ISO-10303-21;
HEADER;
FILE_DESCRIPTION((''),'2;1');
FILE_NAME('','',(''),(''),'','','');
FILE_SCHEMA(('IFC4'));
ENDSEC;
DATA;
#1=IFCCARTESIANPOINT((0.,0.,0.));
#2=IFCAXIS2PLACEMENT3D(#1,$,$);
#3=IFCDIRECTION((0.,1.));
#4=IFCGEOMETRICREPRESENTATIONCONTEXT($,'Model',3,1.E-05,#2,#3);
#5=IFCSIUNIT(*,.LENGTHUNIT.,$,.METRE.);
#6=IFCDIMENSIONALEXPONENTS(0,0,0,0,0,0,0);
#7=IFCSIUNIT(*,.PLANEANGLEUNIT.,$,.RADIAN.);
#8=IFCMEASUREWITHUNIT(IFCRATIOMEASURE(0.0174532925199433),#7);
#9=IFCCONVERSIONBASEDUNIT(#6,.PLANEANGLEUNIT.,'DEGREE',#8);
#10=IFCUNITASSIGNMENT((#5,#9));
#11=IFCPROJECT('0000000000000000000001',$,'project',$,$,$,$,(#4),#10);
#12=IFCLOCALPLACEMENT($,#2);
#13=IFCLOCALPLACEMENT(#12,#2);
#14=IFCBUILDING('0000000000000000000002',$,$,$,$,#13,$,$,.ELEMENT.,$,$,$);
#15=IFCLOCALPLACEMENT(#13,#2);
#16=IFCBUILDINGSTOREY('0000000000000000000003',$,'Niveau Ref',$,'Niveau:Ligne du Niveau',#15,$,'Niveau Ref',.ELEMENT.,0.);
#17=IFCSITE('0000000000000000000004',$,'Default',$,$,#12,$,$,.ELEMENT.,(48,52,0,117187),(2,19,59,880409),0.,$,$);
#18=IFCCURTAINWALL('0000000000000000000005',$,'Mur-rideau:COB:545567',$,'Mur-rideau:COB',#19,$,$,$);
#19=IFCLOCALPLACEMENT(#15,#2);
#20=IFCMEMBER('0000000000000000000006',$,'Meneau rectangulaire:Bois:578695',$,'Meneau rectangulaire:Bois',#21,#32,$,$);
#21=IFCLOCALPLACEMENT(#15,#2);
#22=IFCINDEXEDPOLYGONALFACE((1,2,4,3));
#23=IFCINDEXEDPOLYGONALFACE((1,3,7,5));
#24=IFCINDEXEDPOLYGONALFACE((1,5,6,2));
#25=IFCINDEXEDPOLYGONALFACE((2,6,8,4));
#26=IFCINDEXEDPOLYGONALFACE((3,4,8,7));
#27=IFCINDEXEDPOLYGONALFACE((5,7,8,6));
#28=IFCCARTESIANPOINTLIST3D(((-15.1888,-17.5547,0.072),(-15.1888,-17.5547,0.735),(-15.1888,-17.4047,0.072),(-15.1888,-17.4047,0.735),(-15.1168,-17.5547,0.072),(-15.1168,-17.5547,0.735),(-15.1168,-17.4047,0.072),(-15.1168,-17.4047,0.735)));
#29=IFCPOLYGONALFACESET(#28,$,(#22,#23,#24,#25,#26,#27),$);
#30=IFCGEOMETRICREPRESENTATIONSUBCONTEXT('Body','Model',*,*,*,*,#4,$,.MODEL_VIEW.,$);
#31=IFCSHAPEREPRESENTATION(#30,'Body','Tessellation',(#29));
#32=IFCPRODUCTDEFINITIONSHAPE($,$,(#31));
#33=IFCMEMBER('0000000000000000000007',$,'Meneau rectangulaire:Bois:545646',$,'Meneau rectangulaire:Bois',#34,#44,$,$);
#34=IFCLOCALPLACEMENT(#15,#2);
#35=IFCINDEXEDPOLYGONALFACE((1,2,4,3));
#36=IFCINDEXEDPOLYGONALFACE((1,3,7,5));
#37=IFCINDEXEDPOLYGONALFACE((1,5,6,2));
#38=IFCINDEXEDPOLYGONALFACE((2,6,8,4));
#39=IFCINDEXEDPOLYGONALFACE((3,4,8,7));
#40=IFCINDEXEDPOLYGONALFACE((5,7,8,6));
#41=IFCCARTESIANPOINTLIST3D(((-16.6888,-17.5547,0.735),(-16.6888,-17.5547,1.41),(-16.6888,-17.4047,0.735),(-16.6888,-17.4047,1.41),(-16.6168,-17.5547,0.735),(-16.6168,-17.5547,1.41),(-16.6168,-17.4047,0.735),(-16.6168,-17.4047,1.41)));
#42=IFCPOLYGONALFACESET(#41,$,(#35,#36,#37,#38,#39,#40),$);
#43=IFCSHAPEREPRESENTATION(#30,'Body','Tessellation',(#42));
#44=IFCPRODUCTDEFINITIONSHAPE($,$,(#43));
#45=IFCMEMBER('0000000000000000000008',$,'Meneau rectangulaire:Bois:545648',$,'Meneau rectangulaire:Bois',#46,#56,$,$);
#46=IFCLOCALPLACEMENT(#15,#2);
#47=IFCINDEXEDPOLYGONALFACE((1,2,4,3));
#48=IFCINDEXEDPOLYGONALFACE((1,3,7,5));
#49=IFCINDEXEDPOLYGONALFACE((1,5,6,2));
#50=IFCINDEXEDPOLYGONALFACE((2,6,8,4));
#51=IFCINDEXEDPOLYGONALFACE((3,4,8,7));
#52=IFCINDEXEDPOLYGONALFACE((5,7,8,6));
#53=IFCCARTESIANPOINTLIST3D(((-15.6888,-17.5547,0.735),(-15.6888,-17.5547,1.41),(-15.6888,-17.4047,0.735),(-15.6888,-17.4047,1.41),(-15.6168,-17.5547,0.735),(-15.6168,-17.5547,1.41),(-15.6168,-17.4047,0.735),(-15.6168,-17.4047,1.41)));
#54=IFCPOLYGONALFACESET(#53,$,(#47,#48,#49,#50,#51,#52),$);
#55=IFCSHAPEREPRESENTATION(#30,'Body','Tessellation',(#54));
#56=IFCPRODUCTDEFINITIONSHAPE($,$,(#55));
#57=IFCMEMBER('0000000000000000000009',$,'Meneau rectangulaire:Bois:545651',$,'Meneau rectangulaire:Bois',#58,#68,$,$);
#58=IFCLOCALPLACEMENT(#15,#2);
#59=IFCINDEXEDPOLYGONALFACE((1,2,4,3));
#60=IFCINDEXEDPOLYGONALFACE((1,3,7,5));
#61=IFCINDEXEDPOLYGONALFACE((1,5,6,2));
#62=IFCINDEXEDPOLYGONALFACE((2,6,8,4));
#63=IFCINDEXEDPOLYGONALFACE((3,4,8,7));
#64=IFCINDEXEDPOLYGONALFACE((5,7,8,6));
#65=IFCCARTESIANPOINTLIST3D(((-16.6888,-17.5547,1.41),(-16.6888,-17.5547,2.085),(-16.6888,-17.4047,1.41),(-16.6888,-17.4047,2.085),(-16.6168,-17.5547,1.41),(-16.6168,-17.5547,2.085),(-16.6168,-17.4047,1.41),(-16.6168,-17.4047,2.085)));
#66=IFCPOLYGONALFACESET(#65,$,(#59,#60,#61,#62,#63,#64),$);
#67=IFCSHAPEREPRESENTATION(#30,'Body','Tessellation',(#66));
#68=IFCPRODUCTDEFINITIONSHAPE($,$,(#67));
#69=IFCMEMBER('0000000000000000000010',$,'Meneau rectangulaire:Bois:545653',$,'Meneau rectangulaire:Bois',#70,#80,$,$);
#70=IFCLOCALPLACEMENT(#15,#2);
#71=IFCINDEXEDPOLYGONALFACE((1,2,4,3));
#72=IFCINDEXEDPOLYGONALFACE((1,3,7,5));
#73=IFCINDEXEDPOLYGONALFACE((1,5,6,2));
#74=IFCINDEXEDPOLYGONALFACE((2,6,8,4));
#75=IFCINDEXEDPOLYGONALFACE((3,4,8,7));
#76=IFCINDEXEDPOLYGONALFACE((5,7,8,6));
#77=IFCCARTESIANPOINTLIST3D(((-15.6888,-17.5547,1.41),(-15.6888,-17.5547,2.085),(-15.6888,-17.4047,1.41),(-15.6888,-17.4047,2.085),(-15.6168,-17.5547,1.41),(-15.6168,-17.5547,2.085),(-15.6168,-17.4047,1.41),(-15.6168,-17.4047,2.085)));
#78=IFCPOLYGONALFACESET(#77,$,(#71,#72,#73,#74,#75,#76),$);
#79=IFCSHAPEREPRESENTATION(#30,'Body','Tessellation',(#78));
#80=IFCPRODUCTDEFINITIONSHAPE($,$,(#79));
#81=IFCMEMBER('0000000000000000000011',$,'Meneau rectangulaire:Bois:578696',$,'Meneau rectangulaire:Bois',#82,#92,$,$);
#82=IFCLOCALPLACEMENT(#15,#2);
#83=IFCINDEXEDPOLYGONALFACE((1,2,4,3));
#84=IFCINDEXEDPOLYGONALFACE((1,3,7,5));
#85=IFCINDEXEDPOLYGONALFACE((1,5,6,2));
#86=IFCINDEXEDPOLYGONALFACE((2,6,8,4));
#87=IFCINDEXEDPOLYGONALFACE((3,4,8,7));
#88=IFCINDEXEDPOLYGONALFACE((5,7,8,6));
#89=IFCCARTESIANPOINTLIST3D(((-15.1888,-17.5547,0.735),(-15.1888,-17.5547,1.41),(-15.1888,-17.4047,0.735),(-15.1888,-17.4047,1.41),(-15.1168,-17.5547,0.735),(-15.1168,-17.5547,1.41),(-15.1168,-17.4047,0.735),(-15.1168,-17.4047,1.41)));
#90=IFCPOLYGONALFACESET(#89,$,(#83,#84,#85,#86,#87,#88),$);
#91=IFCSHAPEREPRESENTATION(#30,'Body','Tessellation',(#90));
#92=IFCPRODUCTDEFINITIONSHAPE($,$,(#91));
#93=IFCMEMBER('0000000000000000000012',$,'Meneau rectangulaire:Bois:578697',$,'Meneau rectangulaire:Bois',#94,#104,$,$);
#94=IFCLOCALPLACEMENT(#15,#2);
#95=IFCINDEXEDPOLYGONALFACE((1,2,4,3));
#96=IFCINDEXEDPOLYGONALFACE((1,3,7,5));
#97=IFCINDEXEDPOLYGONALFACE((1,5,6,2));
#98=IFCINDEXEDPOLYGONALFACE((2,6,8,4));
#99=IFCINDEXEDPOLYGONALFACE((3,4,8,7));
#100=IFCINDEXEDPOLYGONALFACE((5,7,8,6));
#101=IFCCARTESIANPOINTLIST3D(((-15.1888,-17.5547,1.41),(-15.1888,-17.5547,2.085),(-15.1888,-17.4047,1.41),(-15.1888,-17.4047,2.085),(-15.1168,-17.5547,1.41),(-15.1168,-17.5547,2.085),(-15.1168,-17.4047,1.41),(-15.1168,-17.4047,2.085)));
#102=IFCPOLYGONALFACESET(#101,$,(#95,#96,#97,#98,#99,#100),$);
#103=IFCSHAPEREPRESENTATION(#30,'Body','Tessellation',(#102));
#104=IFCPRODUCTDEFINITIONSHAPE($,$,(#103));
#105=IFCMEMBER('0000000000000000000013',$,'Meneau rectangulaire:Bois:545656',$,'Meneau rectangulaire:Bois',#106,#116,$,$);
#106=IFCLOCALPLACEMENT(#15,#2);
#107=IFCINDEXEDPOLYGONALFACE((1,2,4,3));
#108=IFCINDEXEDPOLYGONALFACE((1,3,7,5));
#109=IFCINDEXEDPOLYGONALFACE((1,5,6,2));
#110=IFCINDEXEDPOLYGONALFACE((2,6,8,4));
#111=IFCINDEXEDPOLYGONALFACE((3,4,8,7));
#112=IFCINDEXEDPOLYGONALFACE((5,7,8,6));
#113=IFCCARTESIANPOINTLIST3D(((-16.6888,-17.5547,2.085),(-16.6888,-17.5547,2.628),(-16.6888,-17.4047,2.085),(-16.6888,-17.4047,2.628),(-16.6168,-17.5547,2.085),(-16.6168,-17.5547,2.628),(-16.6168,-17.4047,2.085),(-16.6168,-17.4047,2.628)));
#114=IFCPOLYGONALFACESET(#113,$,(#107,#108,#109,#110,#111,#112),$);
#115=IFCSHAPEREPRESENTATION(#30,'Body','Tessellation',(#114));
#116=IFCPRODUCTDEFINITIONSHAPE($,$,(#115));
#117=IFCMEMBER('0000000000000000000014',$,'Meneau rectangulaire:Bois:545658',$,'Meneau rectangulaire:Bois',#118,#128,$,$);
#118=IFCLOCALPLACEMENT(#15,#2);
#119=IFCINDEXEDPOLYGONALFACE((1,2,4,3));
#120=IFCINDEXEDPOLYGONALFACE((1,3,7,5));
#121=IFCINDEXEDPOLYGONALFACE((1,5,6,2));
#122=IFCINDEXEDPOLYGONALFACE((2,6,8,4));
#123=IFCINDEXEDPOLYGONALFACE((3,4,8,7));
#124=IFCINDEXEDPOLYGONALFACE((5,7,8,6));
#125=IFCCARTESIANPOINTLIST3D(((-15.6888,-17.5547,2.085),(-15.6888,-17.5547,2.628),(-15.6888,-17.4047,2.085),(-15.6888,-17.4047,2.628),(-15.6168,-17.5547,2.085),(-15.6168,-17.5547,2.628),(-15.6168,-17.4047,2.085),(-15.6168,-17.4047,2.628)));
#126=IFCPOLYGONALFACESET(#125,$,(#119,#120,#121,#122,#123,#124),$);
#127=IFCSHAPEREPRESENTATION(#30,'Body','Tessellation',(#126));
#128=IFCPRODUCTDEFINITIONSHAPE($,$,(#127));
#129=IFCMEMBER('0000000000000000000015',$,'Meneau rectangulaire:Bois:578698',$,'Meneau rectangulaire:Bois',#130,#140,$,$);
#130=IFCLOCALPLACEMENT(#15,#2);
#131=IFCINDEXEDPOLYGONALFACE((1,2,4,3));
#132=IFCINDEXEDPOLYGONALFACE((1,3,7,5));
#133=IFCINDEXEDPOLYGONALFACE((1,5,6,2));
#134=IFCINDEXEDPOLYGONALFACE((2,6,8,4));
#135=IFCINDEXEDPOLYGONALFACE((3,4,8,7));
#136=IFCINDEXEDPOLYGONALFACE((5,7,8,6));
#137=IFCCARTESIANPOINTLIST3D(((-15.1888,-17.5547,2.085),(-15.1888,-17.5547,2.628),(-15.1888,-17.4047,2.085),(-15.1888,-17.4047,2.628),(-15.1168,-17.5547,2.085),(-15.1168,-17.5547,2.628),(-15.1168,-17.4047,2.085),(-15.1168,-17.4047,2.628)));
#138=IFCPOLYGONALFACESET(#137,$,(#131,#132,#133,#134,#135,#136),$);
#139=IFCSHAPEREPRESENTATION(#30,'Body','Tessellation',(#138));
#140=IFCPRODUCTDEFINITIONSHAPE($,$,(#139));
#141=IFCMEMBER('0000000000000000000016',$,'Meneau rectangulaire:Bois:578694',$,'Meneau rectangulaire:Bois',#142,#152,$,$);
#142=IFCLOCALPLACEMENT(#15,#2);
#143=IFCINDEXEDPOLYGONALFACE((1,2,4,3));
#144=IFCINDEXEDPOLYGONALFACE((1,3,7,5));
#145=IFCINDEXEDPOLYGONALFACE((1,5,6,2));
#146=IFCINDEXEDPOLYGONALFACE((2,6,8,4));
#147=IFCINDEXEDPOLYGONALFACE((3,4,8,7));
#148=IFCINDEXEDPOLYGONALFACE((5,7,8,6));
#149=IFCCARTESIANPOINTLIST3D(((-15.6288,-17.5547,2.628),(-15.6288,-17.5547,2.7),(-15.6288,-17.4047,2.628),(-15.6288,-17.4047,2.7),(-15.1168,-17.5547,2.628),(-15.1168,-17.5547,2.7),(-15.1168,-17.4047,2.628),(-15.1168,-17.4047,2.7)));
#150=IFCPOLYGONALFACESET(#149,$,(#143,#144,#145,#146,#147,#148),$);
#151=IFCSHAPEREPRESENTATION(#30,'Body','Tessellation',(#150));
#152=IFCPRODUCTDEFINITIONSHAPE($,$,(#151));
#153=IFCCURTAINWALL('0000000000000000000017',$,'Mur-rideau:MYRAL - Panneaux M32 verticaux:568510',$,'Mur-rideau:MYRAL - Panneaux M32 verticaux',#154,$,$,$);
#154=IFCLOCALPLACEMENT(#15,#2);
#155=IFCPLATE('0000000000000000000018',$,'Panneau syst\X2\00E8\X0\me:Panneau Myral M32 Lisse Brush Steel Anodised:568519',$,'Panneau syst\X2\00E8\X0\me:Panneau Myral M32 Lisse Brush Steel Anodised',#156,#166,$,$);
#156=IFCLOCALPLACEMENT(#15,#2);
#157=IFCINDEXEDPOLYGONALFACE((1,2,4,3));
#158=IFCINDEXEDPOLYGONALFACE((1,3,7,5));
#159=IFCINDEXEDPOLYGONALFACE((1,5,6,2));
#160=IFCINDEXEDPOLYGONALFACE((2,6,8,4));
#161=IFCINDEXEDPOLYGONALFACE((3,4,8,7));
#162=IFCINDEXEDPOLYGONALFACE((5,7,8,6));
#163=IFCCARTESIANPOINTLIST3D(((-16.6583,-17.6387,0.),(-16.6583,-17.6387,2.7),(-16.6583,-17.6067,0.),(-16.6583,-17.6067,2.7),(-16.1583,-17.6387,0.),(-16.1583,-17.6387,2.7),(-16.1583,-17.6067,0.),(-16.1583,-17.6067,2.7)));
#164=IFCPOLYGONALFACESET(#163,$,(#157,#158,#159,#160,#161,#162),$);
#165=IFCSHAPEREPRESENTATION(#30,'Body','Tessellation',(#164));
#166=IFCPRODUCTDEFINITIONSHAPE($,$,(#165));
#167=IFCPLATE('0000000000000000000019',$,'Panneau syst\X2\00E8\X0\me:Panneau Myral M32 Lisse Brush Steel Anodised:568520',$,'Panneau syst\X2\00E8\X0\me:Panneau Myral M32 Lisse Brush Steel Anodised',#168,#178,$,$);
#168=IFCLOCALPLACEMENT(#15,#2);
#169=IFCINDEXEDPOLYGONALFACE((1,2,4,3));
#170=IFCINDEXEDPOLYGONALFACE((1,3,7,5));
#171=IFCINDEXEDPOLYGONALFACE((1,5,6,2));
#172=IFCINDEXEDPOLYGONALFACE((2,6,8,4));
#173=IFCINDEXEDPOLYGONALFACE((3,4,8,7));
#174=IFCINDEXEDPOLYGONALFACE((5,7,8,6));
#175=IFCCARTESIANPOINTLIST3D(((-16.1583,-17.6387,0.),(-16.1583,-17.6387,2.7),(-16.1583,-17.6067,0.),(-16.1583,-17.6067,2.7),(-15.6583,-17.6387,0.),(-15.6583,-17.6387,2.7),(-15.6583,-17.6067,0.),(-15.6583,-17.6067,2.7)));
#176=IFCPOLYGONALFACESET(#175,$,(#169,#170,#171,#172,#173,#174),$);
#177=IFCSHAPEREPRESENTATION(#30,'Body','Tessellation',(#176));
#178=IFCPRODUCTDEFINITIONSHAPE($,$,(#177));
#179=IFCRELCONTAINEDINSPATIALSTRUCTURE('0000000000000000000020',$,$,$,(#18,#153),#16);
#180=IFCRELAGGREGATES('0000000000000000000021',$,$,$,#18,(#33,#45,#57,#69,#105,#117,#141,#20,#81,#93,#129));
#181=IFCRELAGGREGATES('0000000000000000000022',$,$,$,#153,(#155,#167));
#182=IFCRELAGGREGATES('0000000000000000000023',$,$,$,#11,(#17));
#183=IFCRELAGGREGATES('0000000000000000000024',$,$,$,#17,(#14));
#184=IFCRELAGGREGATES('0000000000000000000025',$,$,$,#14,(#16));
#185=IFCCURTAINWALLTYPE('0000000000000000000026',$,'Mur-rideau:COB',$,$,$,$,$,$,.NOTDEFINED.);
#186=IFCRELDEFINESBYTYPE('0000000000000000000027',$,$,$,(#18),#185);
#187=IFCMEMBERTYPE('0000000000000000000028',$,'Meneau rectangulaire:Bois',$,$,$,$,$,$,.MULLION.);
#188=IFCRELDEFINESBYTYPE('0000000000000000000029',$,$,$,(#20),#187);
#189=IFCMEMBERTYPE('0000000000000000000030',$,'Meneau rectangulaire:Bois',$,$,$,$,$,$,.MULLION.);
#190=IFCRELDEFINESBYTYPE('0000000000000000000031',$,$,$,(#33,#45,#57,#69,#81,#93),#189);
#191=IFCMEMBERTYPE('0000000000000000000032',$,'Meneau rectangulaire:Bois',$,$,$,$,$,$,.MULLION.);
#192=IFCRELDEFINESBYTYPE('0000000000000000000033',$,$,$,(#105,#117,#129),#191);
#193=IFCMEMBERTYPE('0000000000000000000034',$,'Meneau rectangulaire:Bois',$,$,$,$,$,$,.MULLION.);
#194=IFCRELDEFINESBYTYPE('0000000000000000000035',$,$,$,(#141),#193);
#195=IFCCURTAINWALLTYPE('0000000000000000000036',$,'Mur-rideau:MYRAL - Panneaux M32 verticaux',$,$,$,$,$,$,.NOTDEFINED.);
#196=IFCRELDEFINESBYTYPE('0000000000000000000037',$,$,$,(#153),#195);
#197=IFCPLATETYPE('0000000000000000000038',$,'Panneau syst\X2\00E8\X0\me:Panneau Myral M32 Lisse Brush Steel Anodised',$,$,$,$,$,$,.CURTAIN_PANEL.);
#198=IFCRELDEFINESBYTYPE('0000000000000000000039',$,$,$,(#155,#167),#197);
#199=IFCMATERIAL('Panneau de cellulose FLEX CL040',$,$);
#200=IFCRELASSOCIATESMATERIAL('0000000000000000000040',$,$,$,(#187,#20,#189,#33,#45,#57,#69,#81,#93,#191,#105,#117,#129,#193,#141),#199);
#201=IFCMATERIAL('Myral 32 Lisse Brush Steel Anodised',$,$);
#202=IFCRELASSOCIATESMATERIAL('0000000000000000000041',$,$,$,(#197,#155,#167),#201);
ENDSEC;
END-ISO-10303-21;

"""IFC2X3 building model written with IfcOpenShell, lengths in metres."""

from ifc_helpers import new_model, entity, si_unit, converted_unit, direction, frame, origin, origin_2d_with_axis, place, context, subcontext, project, spatial, rectangle, extrude, source, transform, mapped, material, type_object, type_shapes, element, aggregate, save


model = new_model("IFC2X3")

# Units and contexts
model_context = context("Model", 3, precision=1e-05, world=origin(), true_north=direction((0.0, 1.0)))
body_context = subcontext(model_context, "Body", "Model", "MODEL_VIEW")
ifc_project = project(units=[si_unit("LENGTHUNIT", "METRE"), converted_unit("PLANEANGLEUNIT", "DEGREE", entity("IfcRatioMeasure", 0.0174532925199433), si_unit("PLANEANGLEUNIT", "RADIAN"), dimensions=[0, 0, 0, 0, 0, 0, 0])], contexts=[model_context])

# Site, building, storey
site_placement = place(None, origin())
site = spatial("IfcSite", under=ifc_project, at=site_placement, Name="Default", CompositionType="ELEMENT", RefLatitude=(48, 52, 0, 117187), RefLongitude=(2, 19, 59, 880409), RefElevation=0.0)
building_placement = place(site_placement, origin())
building = spatial("IfcBuilding", under=site, at=building_placement, CompositionType="ELEMENT")
storey_placement = place(building_placement, origin())
storey = spatial("IfcBuildingStorey", under=building, at=storey_placement, Name="Niveau Ref", ObjectType="Niveau:Ligne du Niveau", LongName="Niveau Ref", CompositionType="ELEMENT", Elevation=0.0)

# Curtain wall, members
curtain_wall_type_1 = type_object("IfcCurtainWallType", Name="Mur-rideau:COB", PredefinedType="NOTDEFINED")
curtain_wall_1_placement = place(storey_placement, origin())
curtain_wall_1 = element("IfcCurtainWall", 1, at=curtain_wall_1_placement, inside=storey, type_object=curtain_wall_type_1, Name="Mur-rideau:COB:545567", ObjectType="Mur-rideau:COB")
ifc_material_1 = material(Name="Panneau de cellulose FLEX CL040")
member_type_1 = type_object("IfcMemberType", Name="Meneau rectangulaire:Bois", PredefinedType="MULLION", material=ifc_material_1)
shared_shape_1 = source(origin(), body_context, "Body", "SweptSolid", [
    extrude(rectangle(XDim=0.15, YDim=0.072, at=origin_2d_with_axis()), frame((-0.024, 0.0, -0.663), z_axis=(0.0, 0.0, 1.0), x_axis=(0.0, -1.0, 0.0)), (0.0, 0.0, 1.0), 0.663),
])
type_shapes(member_type_1, [shared_shape_1])
member_1_placement = place(storey_placement, frame((-15.1288, -17.4797, 0.072), z_axis=(0.0, 0.0, -1.0), x_axis=(1.0, 0.0, 0.0)))
member_1 = element("IfcMember", 2, at=member_1_placement, type_object=member_type_1, material=ifc_material_1, Name="Meneau rectangulaire:Bois:578695", ObjectType="Meneau rectangulaire:Bois", context=body_context, shape_type="MappedRepresentation", body=[
    mapped(shared_shape_1, transform((0.0, 0.0, 0.0), scale=1.0)),
])
member_type_2 = type_object("IfcMemberType", Name="Meneau rectangulaire:Bois", PredefinedType="MULLION", material=ifc_material_1)
shared_shape_2 = source(origin(), body_context, "Body", "SweptSolid", [
    extrude(rectangle(XDim=0.15, YDim=0.072, at=origin_2d_with_axis()), frame((-0.024, 0.0, -0.675), z_axis=(0.0, 0.0, 1.0), x_axis=(0.0, -1.0, 0.0)), (0.0, 0.0, 1.0), 0.675),
])
type_shapes(member_type_2, [shared_shape_2])
member_2_placement = place(storey_placement, frame((-16.6288, -17.4797, 0.735), z_axis=(0.0, 0.0, -1.0), x_axis=(1.0, 0.0, 0.0)))
member_2 = element("IfcMember", 3, at=member_2_placement, type_object=member_type_2, material=ifc_material_1, Name="Meneau rectangulaire:Bois:545646", ObjectType="Meneau rectangulaire:Bois", context=body_context, shape_type="MappedRepresentation", body=[
    mapped(shared_shape_2, transform((0.0, 0.0, 0.0), scale=1.0)),
])
member_3_placement = place(storey_placement, frame((-15.6288, -17.4797, 0.735), z_axis=(0.0, 0.0, -1.0), x_axis=(1.0, 0.0, 0.0)))
member_3 = element("IfcMember", 4, at=member_3_placement, type_object=member_type_2, material=ifc_material_1, Name="Meneau rectangulaire:Bois:545648", ObjectType="Meneau rectangulaire:Bois", context=body_context, shape_type="MappedRepresentation", body=[
    mapped(shared_shape_2, transform((0.0, 0.0, 0.0), scale=1.0)),
])
member_4_placement = place(storey_placement, frame((-16.6288, -17.4797, 1.41), z_axis=(0.0, 0.0, -1.0), x_axis=(1.0, 0.0, 0.0)))
member_4 = element("IfcMember", 5, at=member_4_placement, type_object=member_type_2, material=ifc_material_1, Name="Meneau rectangulaire:Bois:545651", ObjectType="Meneau rectangulaire:Bois", context=body_context, shape_type="MappedRepresentation", body=[
    mapped(shared_shape_2, transform((0.0, 0.0, 0.0), scale=1.0)),
])
member_5_placement = place(storey_placement, frame((-15.6288, -17.4797, 1.41), z_axis=(0.0, 0.0, -1.0), x_axis=(1.0, 0.0, 0.0)))
member_5 = element("IfcMember", 6, at=member_5_placement, type_object=member_type_2, material=ifc_material_1, Name="Meneau rectangulaire:Bois:545653", ObjectType="Meneau rectangulaire:Bois", context=body_context, shape_type="MappedRepresentation", body=[
    mapped(shared_shape_2, transform((0.0, 0.0, 0.0), scale=1.0)),
])
member_6_placement = place(storey_placement, frame((-15.1288, -17.4797, 0.735), z_axis=(0.0, 0.0, -1.0), x_axis=(1.0, 0.0, 0.0)))
member_6 = element("IfcMember", 7, at=member_6_placement, type_object=member_type_2, material=ifc_material_1, Name="Meneau rectangulaire:Bois:578696", ObjectType="Meneau rectangulaire:Bois", context=body_context, shape_type="MappedRepresentation", body=[
    mapped(shared_shape_2, transform((0.0, 0.0, 0.0), scale=1.0)),
])
member_7_placement = place(storey_placement, frame((-15.1288, -17.4797, 1.41), z_axis=(0.0, 0.0, -1.0), x_axis=(1.0, 0.0, 0.0)))
member_7 = element("IfcMember", 8, at=member_7_placement, type_object=member_type_2, material=ifc_material_1, Name="Meneau rectangulaire:Bois:578697", ObjectType="Meneau rectangulaire:Bois", context=body_context, shape_type="MappedRepresentation", body=[
    mapped(shared_shape_2, transform((0.0, 0.0, 0.0), scale=1.0)),
])
member_type_3 = type_object("IfcMemberType", Name="Meneau rectangulaire:Bois", PredefinedType="MULLION", material=ifc_material_1)
shared_shape_3 = source(origin(), body_context, "Body", "SweptSolid", [
    extrude(rectangle(XDim=0.15, YDim=0.072, at=origin_2d_with_axis()), frame((-0.024, 0.0, -0.543), z_axis=(0.0, 0.0, 1.0), x_axis=(0.0, -1.0, 0.0)), (0.0, 0.0, 1.0), 0.543),
])
type_shapes(member_type_3, [shared_shape_3])
member_8_placement = place(storey_placement, frame((-16.6288, -17.4797, 2.085), z_axis=(0.0, 0.0, -1.0), x_axis=(1.0, 0.0, 0.0)))
member_8 = element("IfcMember", 9, at=member_8_placement, type_object=member_type_3, material=ifc_material_1, Name="Meneau rectangulaire:Bois:545656", ObjectType="Meneau rectangulaire:Bois", context=body_context, shape_type="MappedRepresentation", body=[
    mapped(shared_shape_3, transform((0.0, 0.0, 0.0), scale=1.0)),
])
member_9_placement = place(storey_placement, frame((-15.6288, -17.4797, 2.085), z_axis=(0.0, 0.0, -1.0), x_axis=(1.0, 0.0, 0.0)))
member_9 = element("IfcMember", 10, at=member_9_placement, type_object=member_type_3, material=ifc_material_1, Name="Meneau rectangulaire:Bois:545658", ObjectType="Meneau rectangulaire:Bois", context=body_context, shape_type="MappedRepresentation", body=[
    mapped(shared_shape_3, transform((0.0, 0.0, 0.0), scale=1.0)),
])
member_10_placement = place(storey_placement, frame((-15.1288, -17.4797, 2.085), z_axis=(0.0, 0.0, -1.0), x_axis=(1.0, 0.0, 0.0)))
member_10 = element("IfcMember", 11, at=member_10_placement, type_object=member_type_3, material=ifc_material_1, Name="Meneau rectangulaire:Bois:578698", ObjectType="Meneau rectangulaire:Bois", context=body_context, shape_type="MappedRepresentation", body=[
    mapped(shared_shape_3, transform((0.0, 0.0, 0.0), scale=1.0)),
])
member_type_4 = type_object("IfcMemberType", Name="Meneau rectangulaire:Bois", PredefinedType="MULLION", material=ifc_material_1)
shared_shape_4 = source(origin(), body_context, "Body", "SweptSolid", [
    extrude(rectangle(XDim=0.15, YDim=0.072, at=origin_2d_with_axis()), frame((-0.036, 0.0, -0.512), z_axis=(0.0, 0.0, 1.0), x_axis=(0.0, -1.0, 0.0)), (0.0, 0.0, 1.0), 0.512),
])
type_shapes(member_type_4, [shared_shape_4])
member_11_placement = place(storey_placement, frame((-15.1168, -17.4797, 2.7), z_axis=(1.0, 0.0, 0.0), x_axis=(0.0, 0.0, 1.0)))
member_11 = element("IfcMember", 12, at=member_11_placement, type_object=member_type_4, material=ifc_material_1, Name="Meneau rectangulaire:Bois:578694", ObjectType="Meneau rectangulaire:Bois", context=body_context, shape_type="MappedRepresentation", body=[
    mapped(shared_shape_4, transform((0.0, 0.0, 0.0), scale=1.0)),
])
aggregate(curtain_wall_1, [member_2, member_3, member_4, member_5, member_8, member_9, member_11, member_1, member_6, member_7, member_10])

# Curtain wall, plates
curtain_wall_type_2 = type_object("IfcCurtainWallType", Name="Mur-rideau:MYRAL - Panneaux M32 verticaux", PredefinedType="NOTDEFINED")
curtain_wall_2_placement = place(storey_placement, origin())
curtain_wall_2 = element("IfcCurtainWall", 13, at=curtain_wall_2_placement, inside=storey, type_object=curtain_wall_type_2, Name="Mur-rideau:MYRAL - Panneaux M32 verticaux:568510", ObjectType="Mur-rideau:MYRAL - Panneaux M32 verticaux")
ifc_material_2 = material(Name="Myral 32 Lisse Brush Steel Anodised")
plate_type = type_object("IfcPlateType", Name="Panneau système:Panneau Myral M32 Lisse Brush Steel Anodised", PredefinedType="CURTAIN_PANEL", material=ifc_material_2)
shared_shape_5 = source(origin(), body_context, "Body", "SweptSolid", [
    extrude(rectangle(XDim=0.032, YDim=0.5, at=origin_2d_with_axis()), frame((0.0, -0.016, 0.0), z_axis=(0.0, 0.0, 1.0), x_axis=(0.0, 1.0, 0.0)), (0.0, 0.0, 1.0), 2.7),
])
type_shapes(plate_type, [shared_shape_5])
plate_1_placement = place(curtain_wall_2_placement, frame((-16.4083, -17.6067, 0.0)))
plate_1 = element("IfcPlate", 14, at=plate_1_placement, type_object=plate_type, material=ifc_material_2, Name="Panneau système:Panneau Myral M32 Lisse Brush Steel Anodised:568519", ObjectType="Panneau système:Panneau Myral M32 Lisse Brush Steel Anodised", context=body_context, shape_type="MappedRepresentation", body=[
    mapped(shared_shape_5, transform((0.0, 0.0, 0.0), scale=1.0)),
])
plate_2_placement = place(curtain_wall_2_placement, frame((-15.9083, -17.6067, 0.0)))
plate_2 = element("IfcPlate", 15, at=plate_2_placement, type_object=plate_type, material=ifc_material_2, Name="Panneau système:Panneau Myral M32 Lisse Brush Steel Anodised:568520", ObjectType="Panneau système:Panneau Myral M32 Lisse Brush Steel Anodised", context=body_context, shape_type="MappedRepresentation", body=[
    mapped(shared_shape_5, transform((0.0, 0.0, 0.0), scale=1.0)),
])
aggregate(curtain_wall_2, [plate_1, plate_2])

save(model, "model.ifc")
